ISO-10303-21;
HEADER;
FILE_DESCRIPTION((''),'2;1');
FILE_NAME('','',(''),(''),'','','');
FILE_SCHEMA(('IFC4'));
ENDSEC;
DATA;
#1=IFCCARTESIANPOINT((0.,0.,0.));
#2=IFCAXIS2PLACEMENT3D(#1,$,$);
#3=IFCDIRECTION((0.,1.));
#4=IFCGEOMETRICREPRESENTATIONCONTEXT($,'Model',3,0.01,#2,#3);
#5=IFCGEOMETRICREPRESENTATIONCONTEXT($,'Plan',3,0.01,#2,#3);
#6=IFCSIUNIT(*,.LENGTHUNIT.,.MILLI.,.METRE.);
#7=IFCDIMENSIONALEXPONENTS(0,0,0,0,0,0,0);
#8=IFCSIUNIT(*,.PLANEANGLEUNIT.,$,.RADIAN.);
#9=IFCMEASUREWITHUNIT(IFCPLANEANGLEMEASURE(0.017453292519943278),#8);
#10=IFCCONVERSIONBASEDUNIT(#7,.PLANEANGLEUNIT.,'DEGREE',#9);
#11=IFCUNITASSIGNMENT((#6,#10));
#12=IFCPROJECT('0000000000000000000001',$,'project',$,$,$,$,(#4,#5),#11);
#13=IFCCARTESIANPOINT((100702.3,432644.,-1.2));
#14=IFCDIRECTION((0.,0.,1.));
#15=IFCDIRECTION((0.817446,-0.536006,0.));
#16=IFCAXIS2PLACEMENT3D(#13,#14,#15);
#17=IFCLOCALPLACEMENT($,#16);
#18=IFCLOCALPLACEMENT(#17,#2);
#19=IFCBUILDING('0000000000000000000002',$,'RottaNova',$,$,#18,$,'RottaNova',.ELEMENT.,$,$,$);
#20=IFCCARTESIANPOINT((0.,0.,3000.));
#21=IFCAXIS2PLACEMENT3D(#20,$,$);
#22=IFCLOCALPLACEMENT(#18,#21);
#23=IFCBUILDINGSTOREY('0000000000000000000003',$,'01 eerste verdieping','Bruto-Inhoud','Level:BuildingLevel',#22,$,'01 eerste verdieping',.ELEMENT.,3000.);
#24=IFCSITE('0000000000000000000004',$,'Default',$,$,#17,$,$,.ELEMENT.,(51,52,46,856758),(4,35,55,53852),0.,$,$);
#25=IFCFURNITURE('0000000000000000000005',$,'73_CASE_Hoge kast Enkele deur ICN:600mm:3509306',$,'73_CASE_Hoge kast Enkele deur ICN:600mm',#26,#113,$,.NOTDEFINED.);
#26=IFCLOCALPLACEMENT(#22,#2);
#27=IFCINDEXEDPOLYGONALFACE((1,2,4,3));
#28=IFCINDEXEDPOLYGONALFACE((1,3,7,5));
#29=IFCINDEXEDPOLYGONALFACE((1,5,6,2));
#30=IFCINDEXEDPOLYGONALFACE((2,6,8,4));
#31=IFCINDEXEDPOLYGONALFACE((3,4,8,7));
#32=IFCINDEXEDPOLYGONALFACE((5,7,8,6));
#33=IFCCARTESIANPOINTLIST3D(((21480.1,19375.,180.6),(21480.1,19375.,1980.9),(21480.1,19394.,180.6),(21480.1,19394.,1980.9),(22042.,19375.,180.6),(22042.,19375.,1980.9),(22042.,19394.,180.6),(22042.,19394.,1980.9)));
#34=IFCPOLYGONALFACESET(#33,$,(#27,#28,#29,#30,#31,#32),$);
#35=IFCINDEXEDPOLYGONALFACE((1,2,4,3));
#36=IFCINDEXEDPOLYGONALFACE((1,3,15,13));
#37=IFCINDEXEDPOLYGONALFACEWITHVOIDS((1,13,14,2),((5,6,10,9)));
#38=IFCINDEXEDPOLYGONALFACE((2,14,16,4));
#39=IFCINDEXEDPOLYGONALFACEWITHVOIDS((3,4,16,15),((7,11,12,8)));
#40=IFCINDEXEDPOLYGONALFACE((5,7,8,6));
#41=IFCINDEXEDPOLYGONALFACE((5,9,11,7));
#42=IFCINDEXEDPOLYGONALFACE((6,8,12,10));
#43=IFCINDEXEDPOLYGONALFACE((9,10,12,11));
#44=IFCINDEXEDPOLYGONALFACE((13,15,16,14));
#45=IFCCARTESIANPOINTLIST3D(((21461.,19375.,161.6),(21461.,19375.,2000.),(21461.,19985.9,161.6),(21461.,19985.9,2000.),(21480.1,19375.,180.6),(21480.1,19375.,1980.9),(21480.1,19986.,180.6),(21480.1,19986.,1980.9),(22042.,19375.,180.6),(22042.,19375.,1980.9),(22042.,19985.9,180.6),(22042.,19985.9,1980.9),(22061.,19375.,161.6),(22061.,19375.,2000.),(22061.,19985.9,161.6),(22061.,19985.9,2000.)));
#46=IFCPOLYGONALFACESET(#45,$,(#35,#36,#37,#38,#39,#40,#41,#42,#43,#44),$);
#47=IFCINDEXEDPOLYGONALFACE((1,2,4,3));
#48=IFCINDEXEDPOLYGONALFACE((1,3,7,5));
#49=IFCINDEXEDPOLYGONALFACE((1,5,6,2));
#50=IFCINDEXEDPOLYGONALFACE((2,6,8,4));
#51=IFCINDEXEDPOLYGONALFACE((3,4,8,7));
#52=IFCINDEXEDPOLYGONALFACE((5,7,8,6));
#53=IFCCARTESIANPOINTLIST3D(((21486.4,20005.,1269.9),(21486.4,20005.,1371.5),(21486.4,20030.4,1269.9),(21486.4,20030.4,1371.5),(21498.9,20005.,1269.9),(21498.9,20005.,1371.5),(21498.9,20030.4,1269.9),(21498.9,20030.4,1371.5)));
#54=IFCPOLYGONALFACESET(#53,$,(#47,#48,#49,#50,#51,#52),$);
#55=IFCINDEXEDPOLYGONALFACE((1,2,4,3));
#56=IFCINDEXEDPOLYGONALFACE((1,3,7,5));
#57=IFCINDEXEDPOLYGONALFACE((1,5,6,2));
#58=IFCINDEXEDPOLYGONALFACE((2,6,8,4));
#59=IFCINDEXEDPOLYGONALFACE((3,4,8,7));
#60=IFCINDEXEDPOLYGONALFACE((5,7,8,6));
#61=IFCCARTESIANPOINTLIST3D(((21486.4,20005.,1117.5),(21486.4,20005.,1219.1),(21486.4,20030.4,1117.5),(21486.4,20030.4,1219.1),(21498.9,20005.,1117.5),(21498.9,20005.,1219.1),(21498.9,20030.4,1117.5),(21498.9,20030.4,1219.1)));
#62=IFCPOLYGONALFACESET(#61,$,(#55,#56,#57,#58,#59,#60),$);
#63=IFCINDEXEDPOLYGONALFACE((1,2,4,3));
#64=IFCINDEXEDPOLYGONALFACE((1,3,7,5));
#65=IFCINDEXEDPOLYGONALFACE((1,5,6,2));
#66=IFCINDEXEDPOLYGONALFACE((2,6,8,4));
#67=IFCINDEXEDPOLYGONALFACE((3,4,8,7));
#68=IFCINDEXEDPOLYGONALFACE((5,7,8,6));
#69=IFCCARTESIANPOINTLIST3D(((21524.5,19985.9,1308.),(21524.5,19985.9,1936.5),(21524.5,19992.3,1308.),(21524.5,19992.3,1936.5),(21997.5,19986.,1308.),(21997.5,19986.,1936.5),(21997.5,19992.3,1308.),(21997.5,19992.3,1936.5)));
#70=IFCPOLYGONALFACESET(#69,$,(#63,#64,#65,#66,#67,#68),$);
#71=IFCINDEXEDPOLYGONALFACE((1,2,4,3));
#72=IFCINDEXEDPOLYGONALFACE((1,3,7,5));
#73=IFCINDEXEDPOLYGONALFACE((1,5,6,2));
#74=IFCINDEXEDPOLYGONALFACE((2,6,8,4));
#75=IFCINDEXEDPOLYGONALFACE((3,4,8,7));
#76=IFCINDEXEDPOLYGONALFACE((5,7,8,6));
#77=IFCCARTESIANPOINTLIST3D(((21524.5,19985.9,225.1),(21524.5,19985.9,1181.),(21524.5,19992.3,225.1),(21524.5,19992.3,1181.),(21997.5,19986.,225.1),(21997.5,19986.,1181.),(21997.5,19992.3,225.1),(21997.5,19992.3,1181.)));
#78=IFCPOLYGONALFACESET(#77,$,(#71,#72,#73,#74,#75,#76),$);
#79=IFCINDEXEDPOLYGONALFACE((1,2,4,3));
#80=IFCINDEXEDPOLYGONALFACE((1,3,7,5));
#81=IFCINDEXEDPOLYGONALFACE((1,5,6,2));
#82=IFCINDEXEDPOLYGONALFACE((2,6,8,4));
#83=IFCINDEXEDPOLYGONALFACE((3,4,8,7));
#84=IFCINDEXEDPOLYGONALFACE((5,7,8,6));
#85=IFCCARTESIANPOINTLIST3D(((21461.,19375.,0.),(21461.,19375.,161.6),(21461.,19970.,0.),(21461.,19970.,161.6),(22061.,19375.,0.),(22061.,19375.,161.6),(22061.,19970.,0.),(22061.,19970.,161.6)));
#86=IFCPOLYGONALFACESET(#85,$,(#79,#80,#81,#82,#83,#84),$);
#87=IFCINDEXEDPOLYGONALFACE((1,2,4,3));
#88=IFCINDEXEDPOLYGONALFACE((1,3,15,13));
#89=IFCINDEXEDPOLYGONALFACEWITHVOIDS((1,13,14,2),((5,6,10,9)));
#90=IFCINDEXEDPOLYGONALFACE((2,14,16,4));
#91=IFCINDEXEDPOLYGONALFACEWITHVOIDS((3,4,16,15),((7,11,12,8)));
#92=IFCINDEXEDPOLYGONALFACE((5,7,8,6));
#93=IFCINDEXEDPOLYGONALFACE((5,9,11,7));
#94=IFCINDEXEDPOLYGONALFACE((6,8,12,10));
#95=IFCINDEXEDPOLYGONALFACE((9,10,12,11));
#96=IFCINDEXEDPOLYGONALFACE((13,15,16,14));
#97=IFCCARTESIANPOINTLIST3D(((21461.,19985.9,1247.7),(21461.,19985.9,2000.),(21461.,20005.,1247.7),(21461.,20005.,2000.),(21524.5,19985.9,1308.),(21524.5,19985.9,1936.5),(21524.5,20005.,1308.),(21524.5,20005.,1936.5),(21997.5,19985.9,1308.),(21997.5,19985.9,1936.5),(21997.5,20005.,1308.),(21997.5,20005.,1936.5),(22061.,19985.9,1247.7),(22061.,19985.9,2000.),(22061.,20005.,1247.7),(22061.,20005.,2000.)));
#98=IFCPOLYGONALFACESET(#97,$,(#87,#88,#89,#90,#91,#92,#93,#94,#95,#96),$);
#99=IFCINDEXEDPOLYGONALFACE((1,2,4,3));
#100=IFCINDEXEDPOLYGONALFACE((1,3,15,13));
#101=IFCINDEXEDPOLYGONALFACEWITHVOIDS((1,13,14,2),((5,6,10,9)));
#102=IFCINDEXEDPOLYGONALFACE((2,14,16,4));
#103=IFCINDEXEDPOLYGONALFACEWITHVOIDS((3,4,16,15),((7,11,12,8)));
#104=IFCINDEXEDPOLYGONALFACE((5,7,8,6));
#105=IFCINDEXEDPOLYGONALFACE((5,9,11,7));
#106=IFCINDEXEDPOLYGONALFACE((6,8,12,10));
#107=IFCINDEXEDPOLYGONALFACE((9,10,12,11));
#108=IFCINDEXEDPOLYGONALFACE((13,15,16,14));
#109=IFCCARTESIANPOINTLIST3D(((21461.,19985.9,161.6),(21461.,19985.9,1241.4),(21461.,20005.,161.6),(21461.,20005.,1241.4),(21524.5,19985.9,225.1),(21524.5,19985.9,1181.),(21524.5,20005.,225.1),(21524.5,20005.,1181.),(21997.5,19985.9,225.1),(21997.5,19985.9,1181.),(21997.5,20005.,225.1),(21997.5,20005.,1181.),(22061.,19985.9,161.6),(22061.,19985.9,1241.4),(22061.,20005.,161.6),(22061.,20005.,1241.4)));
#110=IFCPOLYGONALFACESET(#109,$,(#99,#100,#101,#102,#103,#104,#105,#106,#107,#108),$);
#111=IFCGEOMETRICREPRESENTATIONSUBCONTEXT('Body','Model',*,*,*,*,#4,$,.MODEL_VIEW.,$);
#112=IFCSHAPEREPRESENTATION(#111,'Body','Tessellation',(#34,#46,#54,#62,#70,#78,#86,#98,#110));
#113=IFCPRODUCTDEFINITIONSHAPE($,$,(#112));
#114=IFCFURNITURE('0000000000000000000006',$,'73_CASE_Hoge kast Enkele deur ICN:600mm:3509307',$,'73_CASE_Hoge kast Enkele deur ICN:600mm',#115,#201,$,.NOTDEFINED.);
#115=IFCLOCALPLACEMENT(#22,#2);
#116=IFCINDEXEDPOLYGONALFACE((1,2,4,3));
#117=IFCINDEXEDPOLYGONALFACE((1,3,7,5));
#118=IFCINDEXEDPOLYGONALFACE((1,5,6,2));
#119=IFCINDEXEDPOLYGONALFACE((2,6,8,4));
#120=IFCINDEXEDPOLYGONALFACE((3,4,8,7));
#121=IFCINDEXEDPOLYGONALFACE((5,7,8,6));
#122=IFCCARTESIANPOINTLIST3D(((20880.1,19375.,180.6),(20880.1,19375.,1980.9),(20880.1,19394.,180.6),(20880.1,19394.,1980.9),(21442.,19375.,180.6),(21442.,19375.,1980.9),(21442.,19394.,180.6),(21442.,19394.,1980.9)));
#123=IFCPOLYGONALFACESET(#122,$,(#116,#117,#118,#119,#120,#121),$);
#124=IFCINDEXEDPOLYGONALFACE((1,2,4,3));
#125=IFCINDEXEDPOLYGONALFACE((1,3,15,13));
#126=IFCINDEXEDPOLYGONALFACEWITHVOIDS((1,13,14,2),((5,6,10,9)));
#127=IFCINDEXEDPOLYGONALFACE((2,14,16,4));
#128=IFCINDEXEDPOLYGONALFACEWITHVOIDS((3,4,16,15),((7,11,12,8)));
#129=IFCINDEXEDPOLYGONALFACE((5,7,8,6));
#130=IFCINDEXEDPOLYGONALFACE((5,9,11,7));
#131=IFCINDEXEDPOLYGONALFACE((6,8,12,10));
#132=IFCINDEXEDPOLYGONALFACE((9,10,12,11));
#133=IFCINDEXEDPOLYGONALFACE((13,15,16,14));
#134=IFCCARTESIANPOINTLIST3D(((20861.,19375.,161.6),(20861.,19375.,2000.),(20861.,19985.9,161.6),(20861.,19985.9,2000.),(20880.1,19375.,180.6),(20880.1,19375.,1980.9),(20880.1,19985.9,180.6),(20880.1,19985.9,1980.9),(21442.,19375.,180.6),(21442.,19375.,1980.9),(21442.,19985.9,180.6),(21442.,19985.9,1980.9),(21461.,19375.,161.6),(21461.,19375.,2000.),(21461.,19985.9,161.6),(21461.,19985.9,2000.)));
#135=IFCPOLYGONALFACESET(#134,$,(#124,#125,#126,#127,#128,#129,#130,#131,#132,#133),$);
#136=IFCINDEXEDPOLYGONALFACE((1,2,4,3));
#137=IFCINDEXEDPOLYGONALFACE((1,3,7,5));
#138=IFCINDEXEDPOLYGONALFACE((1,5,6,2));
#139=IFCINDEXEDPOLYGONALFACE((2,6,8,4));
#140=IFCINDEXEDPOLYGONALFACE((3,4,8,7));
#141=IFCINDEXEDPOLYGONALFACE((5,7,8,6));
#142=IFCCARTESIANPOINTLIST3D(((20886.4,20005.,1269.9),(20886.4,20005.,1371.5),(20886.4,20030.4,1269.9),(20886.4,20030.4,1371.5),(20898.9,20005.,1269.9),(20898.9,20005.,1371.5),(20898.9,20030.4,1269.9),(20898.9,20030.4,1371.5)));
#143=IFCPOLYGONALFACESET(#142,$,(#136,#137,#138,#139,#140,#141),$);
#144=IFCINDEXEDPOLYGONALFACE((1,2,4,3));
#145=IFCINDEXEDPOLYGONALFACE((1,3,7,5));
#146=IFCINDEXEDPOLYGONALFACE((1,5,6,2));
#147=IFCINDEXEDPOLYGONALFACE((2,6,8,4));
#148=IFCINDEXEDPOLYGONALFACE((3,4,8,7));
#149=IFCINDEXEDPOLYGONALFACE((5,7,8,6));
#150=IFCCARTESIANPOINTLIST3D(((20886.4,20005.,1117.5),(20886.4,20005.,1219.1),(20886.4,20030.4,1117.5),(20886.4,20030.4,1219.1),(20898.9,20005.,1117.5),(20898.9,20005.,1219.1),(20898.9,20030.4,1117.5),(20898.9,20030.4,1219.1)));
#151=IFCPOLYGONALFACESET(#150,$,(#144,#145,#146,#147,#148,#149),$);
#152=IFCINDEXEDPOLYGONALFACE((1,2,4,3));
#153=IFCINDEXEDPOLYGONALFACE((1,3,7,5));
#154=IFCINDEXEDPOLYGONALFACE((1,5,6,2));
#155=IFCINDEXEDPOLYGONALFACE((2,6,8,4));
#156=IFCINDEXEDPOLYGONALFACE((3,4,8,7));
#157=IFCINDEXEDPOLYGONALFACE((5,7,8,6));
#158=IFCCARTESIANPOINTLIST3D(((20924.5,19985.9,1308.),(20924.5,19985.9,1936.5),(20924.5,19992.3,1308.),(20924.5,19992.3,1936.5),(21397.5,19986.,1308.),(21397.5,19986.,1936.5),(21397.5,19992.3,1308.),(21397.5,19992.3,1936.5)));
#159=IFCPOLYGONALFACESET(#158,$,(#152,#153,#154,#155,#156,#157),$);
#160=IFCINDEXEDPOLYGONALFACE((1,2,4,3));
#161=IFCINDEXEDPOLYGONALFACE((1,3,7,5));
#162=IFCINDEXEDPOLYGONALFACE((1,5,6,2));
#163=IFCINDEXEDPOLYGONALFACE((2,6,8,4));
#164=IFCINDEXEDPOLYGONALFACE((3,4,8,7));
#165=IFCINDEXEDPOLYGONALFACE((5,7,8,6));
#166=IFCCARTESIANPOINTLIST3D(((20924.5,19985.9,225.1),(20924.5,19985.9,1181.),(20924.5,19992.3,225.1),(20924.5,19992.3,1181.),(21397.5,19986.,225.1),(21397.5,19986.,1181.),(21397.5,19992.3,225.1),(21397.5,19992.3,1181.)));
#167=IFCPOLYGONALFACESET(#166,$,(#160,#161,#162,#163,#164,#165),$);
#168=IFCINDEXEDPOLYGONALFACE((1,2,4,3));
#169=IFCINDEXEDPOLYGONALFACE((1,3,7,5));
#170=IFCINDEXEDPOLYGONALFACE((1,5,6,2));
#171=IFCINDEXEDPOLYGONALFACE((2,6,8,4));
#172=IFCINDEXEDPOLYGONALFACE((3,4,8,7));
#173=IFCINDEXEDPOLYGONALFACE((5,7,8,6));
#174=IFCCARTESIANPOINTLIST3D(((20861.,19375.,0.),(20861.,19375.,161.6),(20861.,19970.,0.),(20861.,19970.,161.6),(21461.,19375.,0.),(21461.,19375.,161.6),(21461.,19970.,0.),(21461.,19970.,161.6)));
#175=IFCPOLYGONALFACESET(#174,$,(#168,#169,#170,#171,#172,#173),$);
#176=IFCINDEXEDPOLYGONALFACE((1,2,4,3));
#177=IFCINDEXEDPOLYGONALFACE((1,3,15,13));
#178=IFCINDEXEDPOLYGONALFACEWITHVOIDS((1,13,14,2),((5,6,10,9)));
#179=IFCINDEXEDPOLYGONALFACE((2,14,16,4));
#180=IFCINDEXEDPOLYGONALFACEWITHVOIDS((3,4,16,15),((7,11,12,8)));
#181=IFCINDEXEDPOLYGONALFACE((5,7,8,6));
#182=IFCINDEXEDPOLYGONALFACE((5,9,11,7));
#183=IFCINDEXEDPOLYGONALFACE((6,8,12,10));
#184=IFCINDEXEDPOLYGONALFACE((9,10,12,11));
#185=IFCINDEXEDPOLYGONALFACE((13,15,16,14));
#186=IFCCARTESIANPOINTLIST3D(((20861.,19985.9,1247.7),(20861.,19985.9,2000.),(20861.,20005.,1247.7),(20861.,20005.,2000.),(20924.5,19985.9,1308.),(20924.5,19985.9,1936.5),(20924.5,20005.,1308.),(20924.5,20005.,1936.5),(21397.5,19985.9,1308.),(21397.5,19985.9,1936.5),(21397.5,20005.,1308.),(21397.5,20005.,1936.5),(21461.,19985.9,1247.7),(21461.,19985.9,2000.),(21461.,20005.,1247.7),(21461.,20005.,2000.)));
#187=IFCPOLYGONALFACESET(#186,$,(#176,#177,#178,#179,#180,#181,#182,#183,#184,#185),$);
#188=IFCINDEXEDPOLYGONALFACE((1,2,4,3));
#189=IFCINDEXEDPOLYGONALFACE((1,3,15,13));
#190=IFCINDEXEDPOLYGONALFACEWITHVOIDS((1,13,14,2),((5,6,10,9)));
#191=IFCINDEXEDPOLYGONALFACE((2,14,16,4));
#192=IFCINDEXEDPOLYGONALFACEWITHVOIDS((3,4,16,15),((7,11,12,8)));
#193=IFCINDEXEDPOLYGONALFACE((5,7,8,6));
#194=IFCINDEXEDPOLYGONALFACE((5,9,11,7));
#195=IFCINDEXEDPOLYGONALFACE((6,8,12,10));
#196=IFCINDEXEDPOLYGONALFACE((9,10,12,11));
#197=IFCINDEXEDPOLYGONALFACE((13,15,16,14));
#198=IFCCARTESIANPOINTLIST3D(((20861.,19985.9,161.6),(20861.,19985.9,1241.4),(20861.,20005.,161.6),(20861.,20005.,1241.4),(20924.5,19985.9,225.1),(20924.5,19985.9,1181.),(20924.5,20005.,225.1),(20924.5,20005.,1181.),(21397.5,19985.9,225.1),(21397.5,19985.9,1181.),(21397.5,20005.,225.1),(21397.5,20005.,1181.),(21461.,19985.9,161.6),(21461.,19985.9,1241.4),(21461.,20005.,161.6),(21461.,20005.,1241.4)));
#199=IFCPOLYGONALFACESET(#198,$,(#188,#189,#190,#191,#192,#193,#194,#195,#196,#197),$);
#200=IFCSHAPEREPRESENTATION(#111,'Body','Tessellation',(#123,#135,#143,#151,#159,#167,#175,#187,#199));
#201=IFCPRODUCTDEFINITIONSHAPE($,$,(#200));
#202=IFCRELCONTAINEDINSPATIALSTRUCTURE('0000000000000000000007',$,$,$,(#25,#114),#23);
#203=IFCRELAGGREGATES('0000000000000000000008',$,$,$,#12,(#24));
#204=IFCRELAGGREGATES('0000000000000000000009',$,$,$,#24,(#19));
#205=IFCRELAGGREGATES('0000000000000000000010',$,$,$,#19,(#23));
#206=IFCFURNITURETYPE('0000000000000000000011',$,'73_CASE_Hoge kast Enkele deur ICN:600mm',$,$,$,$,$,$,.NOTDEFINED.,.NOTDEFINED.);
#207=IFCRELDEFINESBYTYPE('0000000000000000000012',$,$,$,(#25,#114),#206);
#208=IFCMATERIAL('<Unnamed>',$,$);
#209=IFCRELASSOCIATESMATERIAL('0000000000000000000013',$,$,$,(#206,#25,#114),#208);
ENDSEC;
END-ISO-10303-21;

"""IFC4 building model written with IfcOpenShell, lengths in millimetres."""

from ifc_helpers import new_model, entity, si_unit, converted_unit, direction, frame, origin, place, context, subcontext, project, spatial, indexed_curve, outline, extrude, source, transform, mapped, material, type_object, type_shapes, element, save


model = new_model("IFC4")

# Units and contexts
model_context = context("Model", 3, precision=0.01, world=origin(), true_north=direction((0.0, 1.0)))
plan_context = context("Plan", 3, precision=0.01, world=origin(), true_north=direction((0.0, 1.0)))
body_context = subcontext(model_context, "Body", "Model", "MODEL_VIEW")
ifc_project = project(units=[si_unit("LENGTHUNIT", "METRE", prefix="MILLI"), converted_unit("PLANEANGLEUNIT", "DEGREE", entity("IfcPlaneAngleMeasure", 0.017453292519943278), si_unit("PLANEANGLEUNIT", "RADIAN"), dimensions=[0, 0, 0, 0, 0, 0, 0])], contexts=[model_context, plan_context])

# Site, building, storey
site_placement = place(None, frame((100702.3, 432644.0, -1.2), z_axis=(0.0, 0.0, 1.0), x_axis=(0.817446, -0.536006, 0.0)))
site = spatial("IfcSite", under=ifc_project, at=site_placement, Name="Default", CompositionType="ELEMENT", RefLatitude=(51, 52, 46, 856758), RefLongitude=(4, 35, 55, 53852), RefElevation=0.0)
building_placement = place(site_placement, origin())
building = spatial("IfcBuilding", under=site, at=building_placement, Name="RottaNova", LongName="RottaNova", CompositionType="ELEMENT")
storey_placement = place(building_placement, frame((0.0, 0.0, 3000.0)))
storey = spatial("IfcBuildingStorey", under=building, at=storey_placement, Name="01 eerste verdieping", Description="Bruto-Inhoud", ObjectType="Level:BuildingLevel", LongName="01 eerste verdieping", CompositionType="ELEMENT", Elevation=3000.0)

# Furniture
ifc_material_1 = material(Name="<Unnamed>")
furniture_type = type_object("IfcFurnitureType", Name="73_CASE_Hoge kast Enkele deur ICN:600mm", AssemblyPlace="NOTDEFINED", PredefinedType="NOTDEFINED", material=ifc_material_1)
shared_shape_1 = source(origin(), body_context, "Body", "SweptSolid", [
    extrude(outline(indexed_curve([(-9.5, -280.9), (9.5, -280.9), (9.5, 280.9), (-9.5, 280.9), (-9.5, -280.9)], self_intersect=False)), frame((18.7, -9.5, 180.6), z_axis=(0.0, 0.0, 1.0), x_axis=(0.0, 1.0, 0.0)), (0.0, 0.0, 1.0), 1800.3),
    extrude(outline(indexed_curve([(-300.0, -919.2), (300.0, -919.2), (300.0, 919.2), (-300.0, 919.2), (-300.0, -919.2)], self_intersect=False), holes=[indexed_curve([(-280.9, 900.2), (281.0, 900.2), (281.0, -900.2), (-280.9, -900.2), (-280.9, 900.2)], self_intersect=False)]), frame((18.7, -610.9, 1080.8), z_axis=(0.0, 1.0, 0.0), x_axis=(-1.0, 0.0, 0.0)), (0.0, 0.0, 1.0), 610.9),
    extrude(outline(indexed_curve([(-12.7, -6.3), (12.7, -6.3), (12.7, 6.3), (-12.7, 6.3), (-12.7, -6.3)], self_intersect=False)), frame((287.1, -642.7, 1269.9), z_axis=(0.0, 0.0, 1.0), x_axis=(0.0, 1.0, 0.0)), (0.0, 0.0, 1.0), 101.6),
    extrude(outline(indexed_curve([(-12.7, -6.3), (12.7, -6.3), (12.7, 6.3), (-12.7, 6.3), (-12.7, -6.3)], self_intersect=False)), frame((287.1, -642.7, 1117.5), z_axis=(0.0, 0.0, 1.0), x_axis=(0.0, 1.0, 0.0)), (0.0, 0.0, 1.0), 101.6),
    extrude(outline(indexed_curve([(-3.2, -236.5), (3.2, -236.5), (3.2, 236.5), (-3.2, 236.5), (-3.2, -236.5)], self_intersect=False)), frame((18.7, -614.1, 1308.0), z_axis=(0.0, 0.0, 1.0), x_axis=(0.0, 1.0, 0.0)), (0.0, 0.0, 1.0), 628.5),
    extrude(outline(indexed_curve([(-3.2, -236.5), (3.2, -236.5), (3.2, 236.5), (-3.2, 236.5), (-3.2, -236.5)], self_intersect=False)), frame((18.7, -614.1, 225.1), z_axis=(0.0, 0.0, 1.0), x_axis=(0.0, 1.0, 0.0)), (0.0, 0.0, 1.0), 956.0),
    extrude(outline(indexed_curve([(-300.0, -297.5), (300.0, -297.5), (300.0, 297.5), (-300.0, 297.5), (-300.0, -297.5)], self_intersect=False)), frame((18.7, -297.5, 0.0), z_axis=(0.0, 0.0, 1.0), x_axis=(-1.0, 0.0, 0.0)), (0.0, 0.0, 1.0), 161.6),
    extrude(outline(indexed_curve([(-376.1, -300.0), (376.1, -300.0), (376.1, 300.0), (-376.1, 300.0), (-376.1, -300.0)], self_intersect=False), holes=[indexed_curve([(-312.6, -236.5), (-312.6, 236.5), (315.8, 236.5), (315.8, -236.5), (-312.6, -236.5)], self_intersect=False)]), frame((18.7, -630.0, 1623.9), z_axis=(0.0, 1.0, 0.0), x_axis=(0.0, 0.0, -1.0)), (0.0, 0.0, 1.0), 19.1),
    extrude(outline(indexed_curve([(-300.0, -539.9), (300.0, -539.9), (300.0, 539.9), (-300.0, 539.9), (-300.0, -539.9)], self_intersect=False), holes=[indexed_curve([(-236.5, 479.6), (236.5, 479.6), (236.5, -476.4), (-236.5, -476.4), (-236.5, 479.6)], self_intersect=False)]), frame((18.7, -630.0, 701.5), z_axis=(0.0, 1.0, 0.0), x_axis=(-1.0, 0.0, 0.0)), (0.0, 0.0, 1.0), 19.1),
])
type_shapes(furniture_type, [shared_shape_1])
for number, where, z_axis, x_axis, name in (
    (1, (21779.7, 19375.0, 0.0), (0.0, 0.0, 1.0), (-1.0, 0.0, 0.0), "73_CASE_Hoge kast Enkele deur ICN:600mm:3509306"),
    (2, (21179.7, 19375.0, 0.0), (0.0, 0.0, 1.0), (-1.0, 0.0, 0.0), "73_CASE_Hoge kast Enkele deur ICN:600mm:3509307"),
):
    element("IfcFurniture", number, at=place(storey_placement, frame(where, z_axis=z_axis, x_axis=x_axis)), inside=storey, type_object=furniture_type, material=ifc_material_1, Name=name, ObjectType="73_CASE_Hoge kast Enkele deur ICN:600mm", PredefinedType="NOTDEFINED", context=body_context, shape_type="MappedRepresentation", body=[
        mapped(shared_shape_1, transform((0.0, 0.0, 0.0), scale=1.0)),
    ])

save(model, "model.ifc")
